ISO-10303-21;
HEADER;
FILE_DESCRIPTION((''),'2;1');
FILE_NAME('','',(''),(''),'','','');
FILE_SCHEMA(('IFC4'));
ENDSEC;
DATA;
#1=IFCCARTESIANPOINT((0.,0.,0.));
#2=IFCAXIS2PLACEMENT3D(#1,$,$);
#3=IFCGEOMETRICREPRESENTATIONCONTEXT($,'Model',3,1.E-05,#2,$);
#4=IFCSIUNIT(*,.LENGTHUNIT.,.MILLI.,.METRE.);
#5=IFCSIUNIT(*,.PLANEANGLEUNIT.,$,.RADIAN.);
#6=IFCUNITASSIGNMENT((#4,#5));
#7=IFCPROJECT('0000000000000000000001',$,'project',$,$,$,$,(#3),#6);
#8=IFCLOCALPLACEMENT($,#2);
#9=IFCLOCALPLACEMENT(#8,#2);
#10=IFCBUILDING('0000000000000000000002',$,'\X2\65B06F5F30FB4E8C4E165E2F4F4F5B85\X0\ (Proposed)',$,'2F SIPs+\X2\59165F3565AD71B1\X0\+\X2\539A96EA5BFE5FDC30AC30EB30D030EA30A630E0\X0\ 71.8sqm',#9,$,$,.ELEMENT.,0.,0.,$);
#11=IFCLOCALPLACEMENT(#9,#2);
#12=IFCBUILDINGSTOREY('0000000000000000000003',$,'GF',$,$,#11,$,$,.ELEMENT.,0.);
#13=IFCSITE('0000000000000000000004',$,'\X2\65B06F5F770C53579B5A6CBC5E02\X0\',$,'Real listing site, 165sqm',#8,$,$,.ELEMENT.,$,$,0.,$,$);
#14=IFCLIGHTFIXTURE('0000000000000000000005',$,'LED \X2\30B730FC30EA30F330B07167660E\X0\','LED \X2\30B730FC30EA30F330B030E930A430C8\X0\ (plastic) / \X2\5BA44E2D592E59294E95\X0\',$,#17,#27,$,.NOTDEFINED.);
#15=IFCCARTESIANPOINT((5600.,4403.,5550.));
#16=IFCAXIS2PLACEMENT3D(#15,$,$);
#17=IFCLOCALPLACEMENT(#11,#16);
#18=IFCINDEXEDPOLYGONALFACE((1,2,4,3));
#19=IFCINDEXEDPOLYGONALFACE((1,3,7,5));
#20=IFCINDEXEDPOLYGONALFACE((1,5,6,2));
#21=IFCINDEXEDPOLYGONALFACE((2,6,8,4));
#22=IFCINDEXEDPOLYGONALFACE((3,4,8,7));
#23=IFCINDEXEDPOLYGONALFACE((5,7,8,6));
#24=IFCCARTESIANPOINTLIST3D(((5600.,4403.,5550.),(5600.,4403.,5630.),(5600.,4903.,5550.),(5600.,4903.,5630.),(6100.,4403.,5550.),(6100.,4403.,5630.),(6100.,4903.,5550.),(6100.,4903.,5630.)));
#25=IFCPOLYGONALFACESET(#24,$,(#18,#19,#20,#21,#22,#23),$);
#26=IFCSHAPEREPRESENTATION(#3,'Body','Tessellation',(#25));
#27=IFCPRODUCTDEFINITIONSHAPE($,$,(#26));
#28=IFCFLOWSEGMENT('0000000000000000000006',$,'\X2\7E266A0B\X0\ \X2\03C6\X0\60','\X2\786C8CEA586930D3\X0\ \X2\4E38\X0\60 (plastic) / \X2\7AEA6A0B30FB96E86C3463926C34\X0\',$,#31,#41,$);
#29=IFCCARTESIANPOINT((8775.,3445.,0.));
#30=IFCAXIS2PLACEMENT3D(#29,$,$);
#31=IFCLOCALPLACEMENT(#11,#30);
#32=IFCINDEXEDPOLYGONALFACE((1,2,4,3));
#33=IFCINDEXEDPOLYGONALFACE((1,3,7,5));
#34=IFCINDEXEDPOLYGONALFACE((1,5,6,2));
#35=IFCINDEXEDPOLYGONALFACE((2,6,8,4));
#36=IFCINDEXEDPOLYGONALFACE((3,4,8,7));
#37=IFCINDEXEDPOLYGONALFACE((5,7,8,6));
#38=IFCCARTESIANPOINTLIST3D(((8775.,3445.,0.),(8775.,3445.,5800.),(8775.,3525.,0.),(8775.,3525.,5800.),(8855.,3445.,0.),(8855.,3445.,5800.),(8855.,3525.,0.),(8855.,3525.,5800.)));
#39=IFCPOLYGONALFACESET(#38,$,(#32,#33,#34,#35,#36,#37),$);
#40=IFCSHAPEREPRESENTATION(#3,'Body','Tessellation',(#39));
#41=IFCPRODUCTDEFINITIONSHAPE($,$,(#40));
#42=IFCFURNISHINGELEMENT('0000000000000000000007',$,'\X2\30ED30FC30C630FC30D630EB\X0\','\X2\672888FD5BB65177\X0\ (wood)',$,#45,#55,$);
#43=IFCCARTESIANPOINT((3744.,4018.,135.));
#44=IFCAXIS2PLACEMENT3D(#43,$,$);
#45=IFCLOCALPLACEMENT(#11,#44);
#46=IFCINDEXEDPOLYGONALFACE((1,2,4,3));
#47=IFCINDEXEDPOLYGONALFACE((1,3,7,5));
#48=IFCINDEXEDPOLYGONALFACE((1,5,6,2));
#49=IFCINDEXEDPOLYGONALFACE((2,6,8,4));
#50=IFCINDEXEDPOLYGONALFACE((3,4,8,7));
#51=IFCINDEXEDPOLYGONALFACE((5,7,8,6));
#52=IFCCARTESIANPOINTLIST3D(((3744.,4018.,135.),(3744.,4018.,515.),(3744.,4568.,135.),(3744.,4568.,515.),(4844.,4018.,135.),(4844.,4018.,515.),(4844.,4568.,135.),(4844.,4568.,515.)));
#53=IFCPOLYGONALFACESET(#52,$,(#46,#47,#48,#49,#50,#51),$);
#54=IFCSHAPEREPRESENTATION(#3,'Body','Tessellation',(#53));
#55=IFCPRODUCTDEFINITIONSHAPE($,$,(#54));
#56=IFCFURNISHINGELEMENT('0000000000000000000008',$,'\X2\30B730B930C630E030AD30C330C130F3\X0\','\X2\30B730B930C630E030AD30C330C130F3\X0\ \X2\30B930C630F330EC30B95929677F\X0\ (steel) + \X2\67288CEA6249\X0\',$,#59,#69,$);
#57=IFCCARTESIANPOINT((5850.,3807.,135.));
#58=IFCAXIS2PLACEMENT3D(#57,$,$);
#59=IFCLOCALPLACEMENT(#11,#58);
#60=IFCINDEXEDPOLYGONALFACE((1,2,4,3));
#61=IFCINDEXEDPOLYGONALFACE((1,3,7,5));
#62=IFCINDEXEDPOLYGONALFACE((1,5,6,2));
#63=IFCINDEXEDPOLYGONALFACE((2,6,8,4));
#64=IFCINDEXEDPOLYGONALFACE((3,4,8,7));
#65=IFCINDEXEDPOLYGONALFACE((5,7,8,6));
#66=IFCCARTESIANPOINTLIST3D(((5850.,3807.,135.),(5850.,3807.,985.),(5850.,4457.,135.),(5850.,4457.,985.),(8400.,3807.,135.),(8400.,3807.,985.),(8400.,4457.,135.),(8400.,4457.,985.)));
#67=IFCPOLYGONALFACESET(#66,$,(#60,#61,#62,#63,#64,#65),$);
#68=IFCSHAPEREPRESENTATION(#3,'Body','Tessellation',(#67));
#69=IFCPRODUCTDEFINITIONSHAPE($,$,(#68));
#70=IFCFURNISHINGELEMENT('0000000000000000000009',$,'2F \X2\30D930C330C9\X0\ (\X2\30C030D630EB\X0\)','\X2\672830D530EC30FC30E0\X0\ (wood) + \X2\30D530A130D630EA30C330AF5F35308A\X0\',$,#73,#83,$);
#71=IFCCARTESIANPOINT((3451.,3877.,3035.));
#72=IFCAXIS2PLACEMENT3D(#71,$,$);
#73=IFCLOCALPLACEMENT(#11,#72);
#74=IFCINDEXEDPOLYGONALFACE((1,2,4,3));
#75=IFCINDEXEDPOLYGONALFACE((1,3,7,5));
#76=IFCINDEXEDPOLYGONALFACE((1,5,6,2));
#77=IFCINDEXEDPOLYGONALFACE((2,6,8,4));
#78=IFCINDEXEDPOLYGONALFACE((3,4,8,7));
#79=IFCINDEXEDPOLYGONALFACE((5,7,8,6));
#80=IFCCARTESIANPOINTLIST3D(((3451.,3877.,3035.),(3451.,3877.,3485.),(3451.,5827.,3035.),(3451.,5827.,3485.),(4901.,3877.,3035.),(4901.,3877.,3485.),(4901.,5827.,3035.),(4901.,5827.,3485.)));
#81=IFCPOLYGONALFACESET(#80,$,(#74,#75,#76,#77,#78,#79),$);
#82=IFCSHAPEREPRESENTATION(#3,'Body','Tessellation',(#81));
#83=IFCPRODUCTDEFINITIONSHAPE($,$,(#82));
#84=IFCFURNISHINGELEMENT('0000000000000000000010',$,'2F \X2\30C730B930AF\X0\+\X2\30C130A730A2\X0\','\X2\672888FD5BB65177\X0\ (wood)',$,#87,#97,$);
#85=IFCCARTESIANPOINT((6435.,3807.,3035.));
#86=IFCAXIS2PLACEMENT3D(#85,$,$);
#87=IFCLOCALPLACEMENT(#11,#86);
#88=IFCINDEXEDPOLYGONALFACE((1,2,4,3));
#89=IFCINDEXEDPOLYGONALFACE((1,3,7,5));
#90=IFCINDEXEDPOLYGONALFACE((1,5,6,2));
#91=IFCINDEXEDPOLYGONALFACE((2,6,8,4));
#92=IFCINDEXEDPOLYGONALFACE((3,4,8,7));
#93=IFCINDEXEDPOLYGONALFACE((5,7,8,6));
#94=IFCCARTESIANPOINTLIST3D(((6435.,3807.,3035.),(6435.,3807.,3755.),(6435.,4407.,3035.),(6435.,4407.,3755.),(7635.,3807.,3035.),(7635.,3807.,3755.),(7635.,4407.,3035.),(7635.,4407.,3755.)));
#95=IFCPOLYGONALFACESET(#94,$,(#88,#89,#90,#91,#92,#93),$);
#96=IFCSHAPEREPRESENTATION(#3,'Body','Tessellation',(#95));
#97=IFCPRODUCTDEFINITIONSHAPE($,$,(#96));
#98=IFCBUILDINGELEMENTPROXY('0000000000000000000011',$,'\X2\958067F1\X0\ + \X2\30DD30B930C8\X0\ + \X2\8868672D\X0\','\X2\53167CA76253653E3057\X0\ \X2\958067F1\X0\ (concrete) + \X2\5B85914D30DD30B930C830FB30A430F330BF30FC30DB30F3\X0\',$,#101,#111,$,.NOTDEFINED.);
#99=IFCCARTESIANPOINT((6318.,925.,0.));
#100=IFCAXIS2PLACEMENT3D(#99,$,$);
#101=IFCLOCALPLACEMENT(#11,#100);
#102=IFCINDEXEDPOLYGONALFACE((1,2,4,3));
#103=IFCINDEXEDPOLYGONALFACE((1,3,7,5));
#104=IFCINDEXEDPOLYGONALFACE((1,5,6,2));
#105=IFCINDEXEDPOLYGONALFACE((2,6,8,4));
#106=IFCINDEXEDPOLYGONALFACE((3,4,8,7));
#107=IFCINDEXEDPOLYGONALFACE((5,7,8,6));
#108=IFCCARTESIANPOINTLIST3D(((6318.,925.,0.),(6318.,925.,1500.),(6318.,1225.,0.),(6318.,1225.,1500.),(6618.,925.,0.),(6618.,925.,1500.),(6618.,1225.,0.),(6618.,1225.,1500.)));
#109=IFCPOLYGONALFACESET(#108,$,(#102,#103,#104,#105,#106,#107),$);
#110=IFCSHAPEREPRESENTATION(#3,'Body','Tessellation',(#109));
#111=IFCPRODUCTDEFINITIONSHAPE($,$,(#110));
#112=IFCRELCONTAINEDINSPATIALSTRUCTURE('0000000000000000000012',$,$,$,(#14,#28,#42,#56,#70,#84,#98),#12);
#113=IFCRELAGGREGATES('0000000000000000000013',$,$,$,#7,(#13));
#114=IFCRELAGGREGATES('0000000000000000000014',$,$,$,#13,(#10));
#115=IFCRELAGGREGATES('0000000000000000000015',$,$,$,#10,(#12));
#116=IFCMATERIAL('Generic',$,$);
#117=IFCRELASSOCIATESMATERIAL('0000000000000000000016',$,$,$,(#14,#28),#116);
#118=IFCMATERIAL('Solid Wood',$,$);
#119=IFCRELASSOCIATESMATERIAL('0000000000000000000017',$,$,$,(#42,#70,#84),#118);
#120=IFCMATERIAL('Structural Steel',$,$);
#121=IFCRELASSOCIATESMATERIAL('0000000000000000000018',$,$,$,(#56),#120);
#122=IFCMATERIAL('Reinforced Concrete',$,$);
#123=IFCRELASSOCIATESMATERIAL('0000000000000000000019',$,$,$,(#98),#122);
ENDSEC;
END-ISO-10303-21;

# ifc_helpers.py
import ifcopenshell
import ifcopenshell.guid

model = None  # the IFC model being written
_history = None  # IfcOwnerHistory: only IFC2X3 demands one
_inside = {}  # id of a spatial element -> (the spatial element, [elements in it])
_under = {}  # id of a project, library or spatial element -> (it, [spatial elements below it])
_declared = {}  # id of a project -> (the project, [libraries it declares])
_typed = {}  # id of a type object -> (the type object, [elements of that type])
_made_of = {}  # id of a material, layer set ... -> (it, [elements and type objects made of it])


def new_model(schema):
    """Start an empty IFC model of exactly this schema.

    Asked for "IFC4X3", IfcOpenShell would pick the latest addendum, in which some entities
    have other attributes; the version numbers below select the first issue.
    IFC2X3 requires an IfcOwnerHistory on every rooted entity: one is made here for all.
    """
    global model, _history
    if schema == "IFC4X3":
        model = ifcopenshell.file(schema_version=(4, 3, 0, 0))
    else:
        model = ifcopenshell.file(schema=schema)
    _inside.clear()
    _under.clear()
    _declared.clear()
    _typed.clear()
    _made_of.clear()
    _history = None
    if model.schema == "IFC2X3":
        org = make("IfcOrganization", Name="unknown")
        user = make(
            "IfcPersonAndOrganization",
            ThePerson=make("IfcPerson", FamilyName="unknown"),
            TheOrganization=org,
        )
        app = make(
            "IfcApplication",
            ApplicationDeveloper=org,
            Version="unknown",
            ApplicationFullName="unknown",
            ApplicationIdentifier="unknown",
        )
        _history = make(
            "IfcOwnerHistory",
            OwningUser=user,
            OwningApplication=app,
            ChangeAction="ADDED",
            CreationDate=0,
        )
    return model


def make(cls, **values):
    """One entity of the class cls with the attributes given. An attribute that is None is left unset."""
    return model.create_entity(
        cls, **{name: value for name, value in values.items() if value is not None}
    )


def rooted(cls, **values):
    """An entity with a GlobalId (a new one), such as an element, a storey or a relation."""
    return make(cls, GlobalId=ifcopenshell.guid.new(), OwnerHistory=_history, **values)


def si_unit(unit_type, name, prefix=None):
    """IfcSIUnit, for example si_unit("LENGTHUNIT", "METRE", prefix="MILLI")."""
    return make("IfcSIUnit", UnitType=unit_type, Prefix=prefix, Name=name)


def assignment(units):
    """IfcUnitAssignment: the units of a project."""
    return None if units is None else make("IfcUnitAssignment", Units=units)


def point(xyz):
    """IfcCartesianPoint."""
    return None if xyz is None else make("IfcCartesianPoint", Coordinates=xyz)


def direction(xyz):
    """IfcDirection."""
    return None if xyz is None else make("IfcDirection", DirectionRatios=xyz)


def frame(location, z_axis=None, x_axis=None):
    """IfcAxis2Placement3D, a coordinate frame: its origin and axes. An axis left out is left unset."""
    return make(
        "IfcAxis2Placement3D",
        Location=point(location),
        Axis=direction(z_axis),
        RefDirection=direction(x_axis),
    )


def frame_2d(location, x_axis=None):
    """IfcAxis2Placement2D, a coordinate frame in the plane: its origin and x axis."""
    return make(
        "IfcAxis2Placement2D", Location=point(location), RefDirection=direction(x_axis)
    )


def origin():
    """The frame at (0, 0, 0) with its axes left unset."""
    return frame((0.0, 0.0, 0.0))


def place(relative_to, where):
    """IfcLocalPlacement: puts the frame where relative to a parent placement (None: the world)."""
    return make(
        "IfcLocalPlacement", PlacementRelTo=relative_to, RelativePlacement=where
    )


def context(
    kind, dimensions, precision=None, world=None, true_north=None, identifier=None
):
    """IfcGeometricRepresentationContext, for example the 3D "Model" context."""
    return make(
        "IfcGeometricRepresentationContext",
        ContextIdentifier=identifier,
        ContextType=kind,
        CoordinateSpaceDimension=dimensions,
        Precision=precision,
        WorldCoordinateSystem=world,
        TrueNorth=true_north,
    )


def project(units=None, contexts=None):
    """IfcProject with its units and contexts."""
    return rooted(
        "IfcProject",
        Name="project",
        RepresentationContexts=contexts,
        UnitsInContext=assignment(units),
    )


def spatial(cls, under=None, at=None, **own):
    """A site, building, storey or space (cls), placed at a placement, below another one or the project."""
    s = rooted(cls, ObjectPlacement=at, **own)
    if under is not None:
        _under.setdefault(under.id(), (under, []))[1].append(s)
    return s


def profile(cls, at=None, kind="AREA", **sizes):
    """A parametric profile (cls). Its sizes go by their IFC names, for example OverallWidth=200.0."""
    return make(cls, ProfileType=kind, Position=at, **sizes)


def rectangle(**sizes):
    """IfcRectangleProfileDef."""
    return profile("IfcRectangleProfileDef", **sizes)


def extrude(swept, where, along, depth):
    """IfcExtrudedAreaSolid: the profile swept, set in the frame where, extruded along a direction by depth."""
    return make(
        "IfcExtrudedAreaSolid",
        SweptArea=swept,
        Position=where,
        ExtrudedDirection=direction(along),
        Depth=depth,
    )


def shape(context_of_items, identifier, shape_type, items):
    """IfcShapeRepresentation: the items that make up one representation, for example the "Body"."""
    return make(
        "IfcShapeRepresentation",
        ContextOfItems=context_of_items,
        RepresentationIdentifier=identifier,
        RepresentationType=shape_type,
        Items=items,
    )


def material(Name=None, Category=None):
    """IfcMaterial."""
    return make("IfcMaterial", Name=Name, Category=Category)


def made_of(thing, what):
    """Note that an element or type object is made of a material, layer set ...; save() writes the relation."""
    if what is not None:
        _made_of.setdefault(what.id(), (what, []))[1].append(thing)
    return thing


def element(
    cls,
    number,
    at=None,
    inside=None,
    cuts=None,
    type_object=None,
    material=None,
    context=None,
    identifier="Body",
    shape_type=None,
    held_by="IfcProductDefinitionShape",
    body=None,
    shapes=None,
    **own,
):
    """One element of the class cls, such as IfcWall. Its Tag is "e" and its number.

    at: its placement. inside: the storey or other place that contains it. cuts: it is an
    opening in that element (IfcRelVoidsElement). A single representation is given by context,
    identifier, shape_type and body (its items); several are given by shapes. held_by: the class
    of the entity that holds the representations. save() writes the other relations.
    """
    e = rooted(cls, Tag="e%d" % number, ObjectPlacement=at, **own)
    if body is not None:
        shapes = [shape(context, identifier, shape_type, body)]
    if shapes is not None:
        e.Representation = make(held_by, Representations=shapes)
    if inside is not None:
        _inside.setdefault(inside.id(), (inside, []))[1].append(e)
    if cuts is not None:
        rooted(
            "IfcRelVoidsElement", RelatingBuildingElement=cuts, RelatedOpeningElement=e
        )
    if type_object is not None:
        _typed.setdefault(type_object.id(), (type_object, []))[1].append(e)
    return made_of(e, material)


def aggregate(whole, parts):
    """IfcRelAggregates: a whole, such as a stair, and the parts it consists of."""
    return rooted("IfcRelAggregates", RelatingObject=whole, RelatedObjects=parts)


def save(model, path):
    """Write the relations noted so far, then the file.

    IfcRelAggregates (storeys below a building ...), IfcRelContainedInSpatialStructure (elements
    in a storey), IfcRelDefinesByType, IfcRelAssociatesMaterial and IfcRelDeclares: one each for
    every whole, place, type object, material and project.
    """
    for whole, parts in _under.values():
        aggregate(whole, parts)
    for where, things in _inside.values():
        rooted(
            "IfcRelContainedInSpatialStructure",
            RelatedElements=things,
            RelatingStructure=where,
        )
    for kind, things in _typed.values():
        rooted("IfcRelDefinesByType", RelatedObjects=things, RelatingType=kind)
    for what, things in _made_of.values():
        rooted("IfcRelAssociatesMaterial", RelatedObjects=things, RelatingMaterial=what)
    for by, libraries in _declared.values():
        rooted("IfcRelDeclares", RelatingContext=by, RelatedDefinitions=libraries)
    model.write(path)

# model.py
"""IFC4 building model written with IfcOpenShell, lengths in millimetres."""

from ifc_helpers import new_model, si_unit, frame, frame_2d, origin, place, context, project, spatial, rectangle, extrude, material, element, save


model = new_model("IFC4")

# Units and contexts
model_context = context("Model", 3, precision=1e-05, world=origin())
ifc_project = project(units=[si_unit("LENGTHUNIT", "METRE", prefix="MILLI"), si_unit("PLANEANGLEUNIT", "RADIAN")], contexts=[model_context])

# Site, building, storey
site_placement = place(None, origin())
site = spatial("IfcSite", under=ifc_project, at=site_placement, Name="新潟県南魚沼市", ObjectType="Real listing site, 165sqm", CompositionType="ELEMENT", RefElevation=0.0)
building_placement = place(site_placement, origin())
building = spatial("IfcBuilding", under=site, at=building_placement, Name="新潟・二世帯住宅 (Proposed)", ObjectType="2F SIPs+外張断熱+厚雪対応ガルバリウム 71.8sqm", CompositionType="ELEMENT", ElevationOfRefHeight=0.0, ElevationOfTerrain=0.0)
storey_placement = place(building_placement, origin())
storey = spatial("IfcBuildingStorey", under=building, at=storey_placement, Name="GF", CompositionType="ELEMENT", Elevation=0.0)

# Shared definitions
ifc_material_1 = material(Name="Solid Wood")

# Shared definitions
ifc_material_2 = material(Name="Reinforced Concrete")

# Shared definitions
ifc_material_3 = material(Name="Structural Steel")

# Shared definitions
ifc_material_4 = material(Name="Generic")

# Light fixture
light_fixture_1_placement = place(storey_placement, frame((5600.0, 4403.0, 5550.0)))
element("IfcLightFixture", 1, at=light_fixture_1_placement, inside=storey, material=ifc_material_4, Name="LED シーリング照明", Description="LED シーリングライト (plastic) / 室中央天井", PredefinedType="NOTDEFINED", context=model_context, shape_type="SweptSolid", body=[
    extrude(rectangle(XDim=500.0, YDim=500.0, at=frame_2d((250.0, 250.0))), frame((5600.0, 4403.0, 5550.0)), (0.0, 0.0, 1.0), 80.0),
])

# Flow segment
flow_segment_placement = place(storey_placement, frame((8775.0, 3445.0, 0.0)))
element("IfcFlowSegment", 2, at=flow_segment_placement, inside=storey, material=ifc_material_4, Name="縦樋 φ60", Description="硬質塩ビ 丸60 (plastic) / 竪樋・雨水排水", context=model_context, shape_type="SweptSolid", body=[
    extrude(rectangle(XDim=80.0, YDim=80.0, at=frame_2d((40.0, 40.0))), frame((8775.0, 3445.0, 0.0)), (0.0, 0.0, 1.0), 5800.0),
])

# Furnishing elements
furnishing_1_placement = place(storey_placement, frame((3744.0, 4018.0, 135.0)))
element("IfcFurnishingElement", 3, at=furnishing_1_placement, inside=storey, material=ifc_material_1, Name="ローテーブル", Description="木製家具 (wood)", context=model_context, shape_type="SweptSolid", body=[
    extrude(rectangle(XDim=1100.0, YDim=550.0, at=frame_2d((550.0, 275.0))), frame((3744.0, 4018.0, 135.0)), (0.0, 0.0, 1.0), 380.0),
])
furnishing_2_placement = place(storey_placement, frame((5850.0, 3807.0, 135.0)))
element("IfcFurnishingElement", 4, at=furnishing_2_placement, inside=storey, material=ifc_material_3, Name="システムキッチン", Description="システムキッチン ステンレス天板 (steel) + 木質扉", context=model_context, shape_type="SweptSolid", body=[
    extrude(rectangle(XDim=2550.0, YDim=650.0, at=frame_2d((1275.0, 325.0))), frame((5850.0, 3807.0, 135.0)), (0.0, 0.0, 1.0), 850.0),
])
furnishing_3_placement = place(storey_placement, frame((3451.0, 3877.0, 3035.0)))
element("IfcFurnishingElement", 5, at=furnishing_3_placement, inside=storey, material=ifc_material_1, Name="2F ベッド (ダブル)", Description="木フレーム (wood) + ファブリック張り", context=model_context, shape_type="SweptSolid", body=[
    extrude(rectangle(XDim=1450.0, YDim=1950.0, at=frame_2d((725.0, 975.0))), frame((3451.0, 3877.0, 3035.0)), (0.0, 0.0, 1.0), 450.0),
])
furnishing_4_placement = place(storey_placement, frame((6435.0, 3807.0, 3035.0)))
element("IfcFurnishingElement", 6, at=furnishing_4_placement, inside=storey, material=ifc_material_1, Name="2F デスク+チェア", Description="木製家具 (wood)", context=model_context, shape_type="SweptSolid", body=[
    extrude(rectangle(XDim=1200.0, YDim=600.0, at=frame_2d((600.0, 300.0))), frame((6435.0, 3807.0, 3035.0)), (0.0, 0.0, 1.0), 720.0),
])

# Building element proxy
proxy_placement = place(storey_placement, frame((6318.0, 925.0, 0.0)))
element("IfcBuildingElementProxy", 7, at=proxy_placement, inside=storey, material=ifc_material_2, Name="門柱 + ポスト + 表札", Description="化粧打放し 門柱 (concrete) + 宅配ポスト・インターホン", PredefinedType="NOTDEFINED", context=model_context, shape_type="SweptSolid", body=[
    extrude(rectangle(XDim=300.0, YDim=300.0, at=frame_2d((150.0, 150.0))), frame((6318.0, 925.0, 0.0)), (0.0, 0.0, 1.0), 1500.0),
])

save(model, "model.ifc")
